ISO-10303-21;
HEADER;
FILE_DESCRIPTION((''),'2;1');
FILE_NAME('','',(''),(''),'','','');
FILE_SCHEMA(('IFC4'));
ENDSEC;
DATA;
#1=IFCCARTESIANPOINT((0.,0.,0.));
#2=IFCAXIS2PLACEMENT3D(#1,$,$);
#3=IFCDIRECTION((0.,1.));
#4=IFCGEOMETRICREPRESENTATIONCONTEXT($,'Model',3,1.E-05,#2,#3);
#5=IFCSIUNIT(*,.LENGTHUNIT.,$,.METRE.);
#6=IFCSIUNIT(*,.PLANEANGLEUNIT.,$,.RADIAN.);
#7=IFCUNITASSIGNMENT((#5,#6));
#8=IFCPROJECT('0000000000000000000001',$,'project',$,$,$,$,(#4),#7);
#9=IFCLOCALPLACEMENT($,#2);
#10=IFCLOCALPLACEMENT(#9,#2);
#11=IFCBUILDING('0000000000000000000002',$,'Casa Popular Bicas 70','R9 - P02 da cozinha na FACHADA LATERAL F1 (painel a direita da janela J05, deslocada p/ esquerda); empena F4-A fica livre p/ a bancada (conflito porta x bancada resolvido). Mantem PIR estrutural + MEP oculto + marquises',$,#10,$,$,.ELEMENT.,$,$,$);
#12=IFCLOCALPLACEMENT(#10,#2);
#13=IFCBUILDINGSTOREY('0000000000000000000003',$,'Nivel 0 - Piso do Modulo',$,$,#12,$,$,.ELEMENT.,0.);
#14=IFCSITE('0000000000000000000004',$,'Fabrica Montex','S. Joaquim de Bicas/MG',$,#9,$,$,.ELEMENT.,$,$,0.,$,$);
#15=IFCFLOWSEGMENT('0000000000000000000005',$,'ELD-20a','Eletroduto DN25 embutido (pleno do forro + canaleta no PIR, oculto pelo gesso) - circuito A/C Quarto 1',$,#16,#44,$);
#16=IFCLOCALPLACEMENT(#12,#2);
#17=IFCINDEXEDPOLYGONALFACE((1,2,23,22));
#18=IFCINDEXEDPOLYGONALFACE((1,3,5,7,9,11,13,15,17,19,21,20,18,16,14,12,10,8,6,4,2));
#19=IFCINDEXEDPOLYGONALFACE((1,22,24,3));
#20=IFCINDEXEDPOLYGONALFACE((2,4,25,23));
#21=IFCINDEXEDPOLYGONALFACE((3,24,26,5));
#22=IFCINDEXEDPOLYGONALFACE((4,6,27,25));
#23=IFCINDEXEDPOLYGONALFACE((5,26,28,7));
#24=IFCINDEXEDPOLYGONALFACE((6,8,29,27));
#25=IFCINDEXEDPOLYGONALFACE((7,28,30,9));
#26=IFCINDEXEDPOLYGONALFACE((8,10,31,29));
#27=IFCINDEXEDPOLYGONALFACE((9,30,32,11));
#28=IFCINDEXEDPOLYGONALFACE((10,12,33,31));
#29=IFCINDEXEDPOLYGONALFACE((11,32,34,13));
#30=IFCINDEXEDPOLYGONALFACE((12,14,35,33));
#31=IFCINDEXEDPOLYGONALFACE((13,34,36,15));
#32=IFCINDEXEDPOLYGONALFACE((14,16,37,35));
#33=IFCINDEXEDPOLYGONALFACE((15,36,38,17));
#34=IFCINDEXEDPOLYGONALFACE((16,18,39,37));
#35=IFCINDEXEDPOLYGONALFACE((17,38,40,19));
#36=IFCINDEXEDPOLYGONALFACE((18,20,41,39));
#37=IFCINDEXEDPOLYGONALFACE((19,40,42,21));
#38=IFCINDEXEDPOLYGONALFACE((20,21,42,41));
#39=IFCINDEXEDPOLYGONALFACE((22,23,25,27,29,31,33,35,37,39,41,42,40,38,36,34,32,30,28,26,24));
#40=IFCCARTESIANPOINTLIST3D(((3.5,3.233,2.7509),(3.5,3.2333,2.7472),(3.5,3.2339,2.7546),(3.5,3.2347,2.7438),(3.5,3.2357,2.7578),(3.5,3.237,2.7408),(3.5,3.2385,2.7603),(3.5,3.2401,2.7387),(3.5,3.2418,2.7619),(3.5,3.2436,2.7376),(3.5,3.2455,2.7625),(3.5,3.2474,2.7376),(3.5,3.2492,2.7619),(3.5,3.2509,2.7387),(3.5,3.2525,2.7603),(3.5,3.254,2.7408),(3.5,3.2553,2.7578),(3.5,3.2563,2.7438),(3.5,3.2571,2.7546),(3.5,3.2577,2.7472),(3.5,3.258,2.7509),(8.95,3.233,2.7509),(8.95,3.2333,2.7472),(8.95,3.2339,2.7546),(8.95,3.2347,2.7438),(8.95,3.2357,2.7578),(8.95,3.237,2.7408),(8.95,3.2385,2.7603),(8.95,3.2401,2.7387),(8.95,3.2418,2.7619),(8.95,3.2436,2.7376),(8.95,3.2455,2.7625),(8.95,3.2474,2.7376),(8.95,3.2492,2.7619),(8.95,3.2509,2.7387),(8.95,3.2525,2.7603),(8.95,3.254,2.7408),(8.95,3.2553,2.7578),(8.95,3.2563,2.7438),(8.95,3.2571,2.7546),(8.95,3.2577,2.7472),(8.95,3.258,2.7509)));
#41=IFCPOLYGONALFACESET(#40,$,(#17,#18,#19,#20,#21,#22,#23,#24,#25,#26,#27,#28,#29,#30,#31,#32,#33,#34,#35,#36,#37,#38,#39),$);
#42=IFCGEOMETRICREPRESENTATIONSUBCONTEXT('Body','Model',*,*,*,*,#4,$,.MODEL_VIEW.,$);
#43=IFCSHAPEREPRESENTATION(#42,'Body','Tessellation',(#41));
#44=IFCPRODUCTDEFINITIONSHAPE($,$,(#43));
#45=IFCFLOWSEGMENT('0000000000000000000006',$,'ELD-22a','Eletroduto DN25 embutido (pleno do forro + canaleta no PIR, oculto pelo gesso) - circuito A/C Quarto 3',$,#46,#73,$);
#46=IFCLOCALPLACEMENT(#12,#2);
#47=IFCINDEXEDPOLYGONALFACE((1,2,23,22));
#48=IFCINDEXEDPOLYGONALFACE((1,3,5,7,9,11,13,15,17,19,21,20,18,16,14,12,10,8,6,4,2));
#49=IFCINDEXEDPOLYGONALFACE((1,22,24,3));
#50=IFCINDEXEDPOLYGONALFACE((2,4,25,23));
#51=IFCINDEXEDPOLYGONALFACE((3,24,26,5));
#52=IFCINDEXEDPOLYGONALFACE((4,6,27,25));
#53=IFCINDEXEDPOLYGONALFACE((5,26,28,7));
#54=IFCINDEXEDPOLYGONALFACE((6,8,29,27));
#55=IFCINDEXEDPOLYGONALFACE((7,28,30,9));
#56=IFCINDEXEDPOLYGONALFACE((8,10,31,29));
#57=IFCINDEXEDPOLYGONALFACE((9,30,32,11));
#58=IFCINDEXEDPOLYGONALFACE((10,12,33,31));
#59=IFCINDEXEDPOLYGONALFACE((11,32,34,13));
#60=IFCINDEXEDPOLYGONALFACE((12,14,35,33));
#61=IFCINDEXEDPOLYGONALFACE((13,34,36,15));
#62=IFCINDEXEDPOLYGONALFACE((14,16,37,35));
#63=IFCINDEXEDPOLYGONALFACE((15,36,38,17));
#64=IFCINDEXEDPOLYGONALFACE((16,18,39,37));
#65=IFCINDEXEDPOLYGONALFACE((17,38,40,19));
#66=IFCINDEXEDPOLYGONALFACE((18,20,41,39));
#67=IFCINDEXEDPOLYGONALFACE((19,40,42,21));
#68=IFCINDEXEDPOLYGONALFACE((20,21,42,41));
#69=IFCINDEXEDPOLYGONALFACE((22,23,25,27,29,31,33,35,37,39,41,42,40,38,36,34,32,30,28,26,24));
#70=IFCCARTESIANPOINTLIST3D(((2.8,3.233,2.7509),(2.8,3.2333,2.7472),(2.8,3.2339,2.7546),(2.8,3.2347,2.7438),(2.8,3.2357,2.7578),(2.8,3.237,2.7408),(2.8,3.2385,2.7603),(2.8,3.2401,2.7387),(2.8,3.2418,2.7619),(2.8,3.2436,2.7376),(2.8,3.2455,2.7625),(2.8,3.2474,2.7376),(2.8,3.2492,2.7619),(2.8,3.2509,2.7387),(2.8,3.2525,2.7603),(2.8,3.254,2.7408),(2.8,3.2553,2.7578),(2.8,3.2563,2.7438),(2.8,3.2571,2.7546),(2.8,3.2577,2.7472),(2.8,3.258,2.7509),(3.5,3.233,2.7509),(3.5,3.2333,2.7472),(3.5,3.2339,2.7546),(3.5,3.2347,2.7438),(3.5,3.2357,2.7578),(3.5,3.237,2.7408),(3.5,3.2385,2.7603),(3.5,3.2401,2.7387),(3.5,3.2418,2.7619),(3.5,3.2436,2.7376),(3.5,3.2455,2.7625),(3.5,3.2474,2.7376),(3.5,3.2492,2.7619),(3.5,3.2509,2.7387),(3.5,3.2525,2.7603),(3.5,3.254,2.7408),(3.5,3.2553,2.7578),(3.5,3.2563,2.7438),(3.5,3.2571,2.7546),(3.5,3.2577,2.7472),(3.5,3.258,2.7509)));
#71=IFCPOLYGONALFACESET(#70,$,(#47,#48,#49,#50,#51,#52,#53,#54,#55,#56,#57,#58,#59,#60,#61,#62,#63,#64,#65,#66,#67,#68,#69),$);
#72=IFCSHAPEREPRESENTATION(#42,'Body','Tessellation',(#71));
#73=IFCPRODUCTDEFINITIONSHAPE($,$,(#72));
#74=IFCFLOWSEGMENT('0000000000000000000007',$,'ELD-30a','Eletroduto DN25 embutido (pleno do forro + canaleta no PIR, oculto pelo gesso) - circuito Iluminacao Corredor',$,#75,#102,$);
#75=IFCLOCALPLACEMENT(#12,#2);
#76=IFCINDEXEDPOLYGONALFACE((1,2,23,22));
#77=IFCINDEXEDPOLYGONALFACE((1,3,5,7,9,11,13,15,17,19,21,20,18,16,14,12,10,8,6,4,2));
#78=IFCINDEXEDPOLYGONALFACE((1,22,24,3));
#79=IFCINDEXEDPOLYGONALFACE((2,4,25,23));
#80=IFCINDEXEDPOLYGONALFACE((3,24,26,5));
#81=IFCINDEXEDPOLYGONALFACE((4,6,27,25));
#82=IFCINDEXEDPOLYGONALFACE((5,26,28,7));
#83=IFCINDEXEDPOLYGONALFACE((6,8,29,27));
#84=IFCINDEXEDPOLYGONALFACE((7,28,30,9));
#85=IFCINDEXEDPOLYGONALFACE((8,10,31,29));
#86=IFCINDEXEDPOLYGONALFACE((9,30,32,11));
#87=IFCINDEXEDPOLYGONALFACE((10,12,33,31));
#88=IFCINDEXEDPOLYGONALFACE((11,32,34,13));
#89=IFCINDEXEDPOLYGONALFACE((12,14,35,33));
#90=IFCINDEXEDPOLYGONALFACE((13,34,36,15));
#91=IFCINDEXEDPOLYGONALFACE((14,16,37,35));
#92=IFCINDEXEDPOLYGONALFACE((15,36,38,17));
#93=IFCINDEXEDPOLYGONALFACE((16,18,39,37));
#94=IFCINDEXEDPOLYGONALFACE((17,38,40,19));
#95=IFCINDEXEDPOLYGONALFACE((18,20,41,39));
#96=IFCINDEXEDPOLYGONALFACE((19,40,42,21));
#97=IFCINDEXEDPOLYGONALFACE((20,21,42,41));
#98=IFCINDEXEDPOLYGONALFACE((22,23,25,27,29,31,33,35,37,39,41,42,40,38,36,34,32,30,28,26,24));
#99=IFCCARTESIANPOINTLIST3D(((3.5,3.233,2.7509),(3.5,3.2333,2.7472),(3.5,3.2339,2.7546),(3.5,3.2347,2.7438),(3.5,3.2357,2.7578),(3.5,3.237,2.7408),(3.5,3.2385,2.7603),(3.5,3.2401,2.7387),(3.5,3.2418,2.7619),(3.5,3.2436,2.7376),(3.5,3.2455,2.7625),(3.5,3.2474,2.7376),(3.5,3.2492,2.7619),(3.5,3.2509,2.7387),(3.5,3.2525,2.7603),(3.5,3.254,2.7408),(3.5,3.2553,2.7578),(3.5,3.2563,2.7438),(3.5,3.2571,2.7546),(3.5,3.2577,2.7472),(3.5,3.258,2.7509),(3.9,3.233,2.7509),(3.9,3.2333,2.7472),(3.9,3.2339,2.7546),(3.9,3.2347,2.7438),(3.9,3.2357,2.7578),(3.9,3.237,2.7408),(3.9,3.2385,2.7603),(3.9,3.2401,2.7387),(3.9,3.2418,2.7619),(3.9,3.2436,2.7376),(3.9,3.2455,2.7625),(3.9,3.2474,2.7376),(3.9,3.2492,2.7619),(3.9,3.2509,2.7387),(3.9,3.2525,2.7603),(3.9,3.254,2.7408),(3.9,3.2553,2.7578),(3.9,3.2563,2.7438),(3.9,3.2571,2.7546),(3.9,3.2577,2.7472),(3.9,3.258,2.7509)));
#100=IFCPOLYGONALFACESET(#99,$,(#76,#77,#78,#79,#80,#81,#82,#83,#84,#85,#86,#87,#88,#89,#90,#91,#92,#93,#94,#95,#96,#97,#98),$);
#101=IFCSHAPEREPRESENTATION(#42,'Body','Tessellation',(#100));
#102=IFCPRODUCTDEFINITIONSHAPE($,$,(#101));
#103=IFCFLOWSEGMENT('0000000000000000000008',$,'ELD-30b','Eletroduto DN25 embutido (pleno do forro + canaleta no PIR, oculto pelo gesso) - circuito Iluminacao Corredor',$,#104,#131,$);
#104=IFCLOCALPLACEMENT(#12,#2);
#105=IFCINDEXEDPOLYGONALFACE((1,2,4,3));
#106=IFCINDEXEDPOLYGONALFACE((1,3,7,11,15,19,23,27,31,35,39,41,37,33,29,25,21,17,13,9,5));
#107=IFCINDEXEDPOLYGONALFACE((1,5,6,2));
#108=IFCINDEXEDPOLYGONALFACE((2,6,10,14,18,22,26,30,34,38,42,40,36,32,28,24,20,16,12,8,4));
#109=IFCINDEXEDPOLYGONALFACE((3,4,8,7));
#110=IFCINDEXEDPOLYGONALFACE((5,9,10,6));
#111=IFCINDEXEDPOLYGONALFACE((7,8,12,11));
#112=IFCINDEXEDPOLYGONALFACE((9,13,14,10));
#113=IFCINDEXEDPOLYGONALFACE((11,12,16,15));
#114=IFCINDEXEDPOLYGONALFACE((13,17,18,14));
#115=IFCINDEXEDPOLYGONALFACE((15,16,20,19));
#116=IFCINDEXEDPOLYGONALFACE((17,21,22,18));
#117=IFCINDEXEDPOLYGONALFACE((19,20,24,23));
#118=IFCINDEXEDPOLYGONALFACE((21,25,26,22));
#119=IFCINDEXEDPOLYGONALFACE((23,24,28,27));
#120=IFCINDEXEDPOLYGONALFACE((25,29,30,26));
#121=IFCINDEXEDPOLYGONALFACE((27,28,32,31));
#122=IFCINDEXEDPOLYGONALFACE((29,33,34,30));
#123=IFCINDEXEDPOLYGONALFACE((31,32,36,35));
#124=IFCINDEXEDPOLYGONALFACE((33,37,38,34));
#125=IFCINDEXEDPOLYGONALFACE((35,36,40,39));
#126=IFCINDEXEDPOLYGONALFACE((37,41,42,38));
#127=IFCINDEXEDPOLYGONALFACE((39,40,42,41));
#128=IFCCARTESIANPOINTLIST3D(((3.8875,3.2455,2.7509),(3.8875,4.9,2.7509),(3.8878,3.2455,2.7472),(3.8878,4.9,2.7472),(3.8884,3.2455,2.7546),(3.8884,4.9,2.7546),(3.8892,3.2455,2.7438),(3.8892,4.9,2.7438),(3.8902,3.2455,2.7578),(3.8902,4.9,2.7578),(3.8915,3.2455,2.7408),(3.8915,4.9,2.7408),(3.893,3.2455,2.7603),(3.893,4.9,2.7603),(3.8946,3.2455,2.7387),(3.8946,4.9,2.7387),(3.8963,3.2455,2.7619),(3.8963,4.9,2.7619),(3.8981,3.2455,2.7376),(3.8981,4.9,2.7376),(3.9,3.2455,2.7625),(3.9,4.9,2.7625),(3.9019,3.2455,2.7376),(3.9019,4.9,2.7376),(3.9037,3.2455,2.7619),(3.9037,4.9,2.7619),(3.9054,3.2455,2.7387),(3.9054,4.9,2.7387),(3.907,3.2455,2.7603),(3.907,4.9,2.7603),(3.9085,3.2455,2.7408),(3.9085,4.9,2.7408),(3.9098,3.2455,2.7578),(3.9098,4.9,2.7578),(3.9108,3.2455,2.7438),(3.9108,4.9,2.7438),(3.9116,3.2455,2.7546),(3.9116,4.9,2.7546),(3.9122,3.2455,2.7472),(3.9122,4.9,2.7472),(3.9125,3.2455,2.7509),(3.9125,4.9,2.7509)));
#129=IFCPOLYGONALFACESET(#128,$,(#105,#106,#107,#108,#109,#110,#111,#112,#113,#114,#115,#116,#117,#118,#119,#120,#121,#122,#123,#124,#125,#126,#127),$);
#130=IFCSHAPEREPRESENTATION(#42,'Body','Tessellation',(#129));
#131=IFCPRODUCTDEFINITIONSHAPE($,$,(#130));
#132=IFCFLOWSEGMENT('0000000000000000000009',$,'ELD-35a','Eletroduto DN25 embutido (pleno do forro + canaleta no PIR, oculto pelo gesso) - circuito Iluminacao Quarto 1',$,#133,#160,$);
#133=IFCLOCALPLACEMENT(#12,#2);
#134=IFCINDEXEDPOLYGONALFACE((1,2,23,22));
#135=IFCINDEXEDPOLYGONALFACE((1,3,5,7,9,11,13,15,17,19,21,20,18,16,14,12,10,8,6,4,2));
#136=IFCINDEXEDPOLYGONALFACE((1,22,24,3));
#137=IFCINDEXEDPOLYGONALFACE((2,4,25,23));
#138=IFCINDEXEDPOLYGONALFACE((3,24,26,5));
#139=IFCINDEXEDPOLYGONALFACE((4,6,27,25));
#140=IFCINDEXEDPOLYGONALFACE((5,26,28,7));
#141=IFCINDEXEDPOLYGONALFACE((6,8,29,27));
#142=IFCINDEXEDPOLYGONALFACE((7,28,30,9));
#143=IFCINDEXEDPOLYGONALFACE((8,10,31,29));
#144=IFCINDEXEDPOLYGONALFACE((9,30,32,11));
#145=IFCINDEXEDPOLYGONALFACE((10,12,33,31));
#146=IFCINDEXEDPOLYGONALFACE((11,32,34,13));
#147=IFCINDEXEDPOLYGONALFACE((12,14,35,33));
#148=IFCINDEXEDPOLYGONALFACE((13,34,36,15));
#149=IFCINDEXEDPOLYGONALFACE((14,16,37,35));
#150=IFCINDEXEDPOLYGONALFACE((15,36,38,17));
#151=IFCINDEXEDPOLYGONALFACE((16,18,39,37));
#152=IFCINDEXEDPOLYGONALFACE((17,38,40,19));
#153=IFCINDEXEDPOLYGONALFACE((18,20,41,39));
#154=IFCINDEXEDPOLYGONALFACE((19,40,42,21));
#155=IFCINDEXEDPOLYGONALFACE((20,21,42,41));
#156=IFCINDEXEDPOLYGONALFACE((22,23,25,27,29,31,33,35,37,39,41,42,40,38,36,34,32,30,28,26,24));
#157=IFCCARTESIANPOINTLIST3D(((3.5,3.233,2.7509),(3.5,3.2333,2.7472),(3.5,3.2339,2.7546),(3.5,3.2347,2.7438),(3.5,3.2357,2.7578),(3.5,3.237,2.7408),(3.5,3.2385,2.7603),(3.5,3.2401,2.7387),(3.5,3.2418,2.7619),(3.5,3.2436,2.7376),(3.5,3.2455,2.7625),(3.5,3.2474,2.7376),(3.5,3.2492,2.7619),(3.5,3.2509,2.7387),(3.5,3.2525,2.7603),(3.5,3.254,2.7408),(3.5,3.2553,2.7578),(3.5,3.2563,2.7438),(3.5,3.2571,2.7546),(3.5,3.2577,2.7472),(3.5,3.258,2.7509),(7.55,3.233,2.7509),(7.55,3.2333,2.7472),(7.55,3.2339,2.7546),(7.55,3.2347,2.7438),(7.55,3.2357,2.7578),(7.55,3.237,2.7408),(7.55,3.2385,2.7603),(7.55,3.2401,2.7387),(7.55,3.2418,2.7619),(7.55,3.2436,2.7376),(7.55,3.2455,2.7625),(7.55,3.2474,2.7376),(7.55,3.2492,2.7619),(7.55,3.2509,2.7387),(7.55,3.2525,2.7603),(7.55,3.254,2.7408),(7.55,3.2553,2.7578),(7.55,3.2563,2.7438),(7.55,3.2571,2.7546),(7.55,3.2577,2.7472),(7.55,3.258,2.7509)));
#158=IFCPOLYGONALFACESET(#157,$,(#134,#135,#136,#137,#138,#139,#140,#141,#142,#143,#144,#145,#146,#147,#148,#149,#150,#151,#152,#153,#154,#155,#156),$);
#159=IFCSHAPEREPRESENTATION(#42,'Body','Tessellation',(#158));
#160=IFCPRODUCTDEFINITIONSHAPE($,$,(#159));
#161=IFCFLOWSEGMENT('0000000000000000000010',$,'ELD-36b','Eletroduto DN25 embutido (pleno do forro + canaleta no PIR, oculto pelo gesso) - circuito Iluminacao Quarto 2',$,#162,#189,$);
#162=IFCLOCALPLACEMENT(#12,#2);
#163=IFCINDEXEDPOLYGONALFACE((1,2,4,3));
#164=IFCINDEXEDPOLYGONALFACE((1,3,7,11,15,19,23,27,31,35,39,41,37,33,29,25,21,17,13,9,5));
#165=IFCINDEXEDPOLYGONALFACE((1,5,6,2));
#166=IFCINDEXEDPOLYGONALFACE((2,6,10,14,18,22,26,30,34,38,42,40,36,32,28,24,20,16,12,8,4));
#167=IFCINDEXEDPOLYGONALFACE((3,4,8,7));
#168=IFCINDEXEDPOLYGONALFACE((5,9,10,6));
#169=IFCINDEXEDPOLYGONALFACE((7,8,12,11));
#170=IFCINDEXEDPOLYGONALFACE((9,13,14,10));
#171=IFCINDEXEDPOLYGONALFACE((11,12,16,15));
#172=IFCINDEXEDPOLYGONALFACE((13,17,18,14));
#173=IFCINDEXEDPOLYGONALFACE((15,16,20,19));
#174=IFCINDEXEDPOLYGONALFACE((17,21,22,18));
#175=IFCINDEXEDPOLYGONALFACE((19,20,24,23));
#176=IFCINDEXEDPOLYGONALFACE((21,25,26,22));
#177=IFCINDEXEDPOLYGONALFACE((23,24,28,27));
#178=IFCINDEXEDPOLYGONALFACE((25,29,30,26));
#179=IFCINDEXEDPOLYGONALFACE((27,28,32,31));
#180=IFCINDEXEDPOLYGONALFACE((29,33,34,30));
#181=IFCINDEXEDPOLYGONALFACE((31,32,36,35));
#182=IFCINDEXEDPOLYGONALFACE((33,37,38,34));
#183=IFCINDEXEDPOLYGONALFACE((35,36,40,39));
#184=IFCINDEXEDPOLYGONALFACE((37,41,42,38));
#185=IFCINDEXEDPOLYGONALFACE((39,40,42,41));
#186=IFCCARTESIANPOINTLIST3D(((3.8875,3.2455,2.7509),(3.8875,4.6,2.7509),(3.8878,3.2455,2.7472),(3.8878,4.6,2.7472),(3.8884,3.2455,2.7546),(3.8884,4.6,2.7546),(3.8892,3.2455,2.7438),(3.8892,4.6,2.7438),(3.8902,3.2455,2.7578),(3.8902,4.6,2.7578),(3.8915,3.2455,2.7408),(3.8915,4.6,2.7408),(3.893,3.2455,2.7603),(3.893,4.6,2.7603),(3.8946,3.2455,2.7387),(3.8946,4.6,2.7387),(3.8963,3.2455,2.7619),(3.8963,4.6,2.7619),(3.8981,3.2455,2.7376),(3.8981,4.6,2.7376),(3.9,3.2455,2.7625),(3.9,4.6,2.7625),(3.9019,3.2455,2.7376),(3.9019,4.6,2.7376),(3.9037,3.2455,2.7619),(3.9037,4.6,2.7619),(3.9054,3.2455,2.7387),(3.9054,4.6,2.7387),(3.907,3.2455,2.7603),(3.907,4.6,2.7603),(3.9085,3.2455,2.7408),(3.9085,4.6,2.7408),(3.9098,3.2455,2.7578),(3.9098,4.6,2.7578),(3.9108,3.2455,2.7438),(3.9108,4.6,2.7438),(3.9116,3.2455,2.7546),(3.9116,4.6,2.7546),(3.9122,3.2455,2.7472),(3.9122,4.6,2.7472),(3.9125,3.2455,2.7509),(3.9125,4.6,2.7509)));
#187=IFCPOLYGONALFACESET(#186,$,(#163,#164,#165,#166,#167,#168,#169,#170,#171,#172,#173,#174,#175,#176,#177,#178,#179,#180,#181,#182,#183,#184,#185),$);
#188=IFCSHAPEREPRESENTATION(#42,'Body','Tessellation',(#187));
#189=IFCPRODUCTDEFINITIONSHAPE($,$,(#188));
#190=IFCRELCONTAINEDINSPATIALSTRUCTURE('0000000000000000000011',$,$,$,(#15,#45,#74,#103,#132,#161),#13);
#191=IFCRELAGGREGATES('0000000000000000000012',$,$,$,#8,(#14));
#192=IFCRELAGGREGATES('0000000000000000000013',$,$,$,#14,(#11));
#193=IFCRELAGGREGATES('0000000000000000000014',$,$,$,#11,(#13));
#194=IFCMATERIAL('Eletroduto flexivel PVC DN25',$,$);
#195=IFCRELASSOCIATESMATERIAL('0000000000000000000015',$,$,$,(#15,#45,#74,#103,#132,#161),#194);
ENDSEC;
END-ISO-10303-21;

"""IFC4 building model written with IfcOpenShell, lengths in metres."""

from ifc_helpers import new_model, si_unit, direction, frame, origin, origin_2d, place, context, subcontext, project, spatial, circle, extrude, material, element, save


model = new_model("IFC4")

# Units and contexts
model_context = context("Model", 3, precision=1e-05, world=origin(), true_north=direction((0.0, 1.0)))
body_context = subcontext(model_context, "Body", "Model", "MODEL_VIEW")
ifc_project = project(units=[si_unit("LENGTHUNIT", "METRE"), si_unit("PLANEANGLEUNIT", "RADIAN")], contexts=[model_context])

# Site, building, storey
site_placement = place(None, origin())
site = spatial("IfcSite", under=ifc_project, at=site_placement, Name="Fabrica Montex", Description="S. Joaquim de Bicas/MG", CompositionType="ELEMENT", RefElevation=0.0)
building_placement = place(site_placement, origin())
building = spatial("IfcBuilding", under=site, at=building_placement, Name="Casa Popular Bicas 70", Description="R9 - P02 da cozinha na FACHADA LATERAL F1 (painel a direita da janela J05, deslocada p/ esquerda); empena F4-A fica livre p/ a bancada (conflito porta x bancada resolvido). Mantem PIR estrutural + MEP oculto + marquises", CompositionType="ELEMENT")
storey_placement = place(building_placement, origin())
storey = spatial("IfcBuildingStorey", under=building, at=storey_placement, Name="Nivel 0 - Piso do Modulo", CompositionType="ELEMENT", Elevation=0.0)

# Flow segments
ifc_material_1 = material(Name="Eletroduto flexivel PVC DN25")
flow_segment_1_placement = place(storey_placement, frame((3.5, 3.2455, 2.75), z_axis=(1.0, 0.0, 0.0), x_axis=(0.0, 0.0, 1.0)))
element("IfcFlowSegment", 1, at=flow_segment_1_placement, inside=storey, material=ifc_material_1, Name="ELD-20a", Description="Eletroduto DN25 embutido (pleno do forro + canaleta no PIR, oculto pelo gesso) - circuito A/C Quarto 1", context=body_context, shape_type="SweptSolid", body=[
    extrude(circle(Radius=0.0125, at=origin_2d()), origin(), (0.0, 0.0, 1.0), 5.45),
])
flow_segment_2_placement = place(storey_placement, frame((3.5, 3.2455, 2.75), z_axis=(-1.0, 0.0, 0.0), x_axis=(0.0, 0.0, 1.0)))
element("IfcFlowSegment", 2, at=flow_segment_2_placement, inside=storey, material=ifc_material_1, Name="ELD-22a", Description="Eletroduto DN25 embutido (pleno do forro + canaleta no PIR, oculto pelo gesso) - circuito A/C Quarto 3", context=body_context, shape_type="SweptSolid", body=[
    extrude(circle(Radius=0.0125, at=origin_2d()), origin(), (0.0, 0.0, 1.0), 0.7),
])
flow_segment_3_placement = place(storey_placement, frame((3.5, 3.2455, 2.75), z_axis=(1.0, 0.0, 0.0), x_axis=(0.0, 0.0, 1.0)))
element("IfcFlowSegment", 3, at=flow_segment_3_placement, inside=storey, material=ifc_material_1, Name="ELD-30a", Description="Eletroduto DN25 embutido (pleno do forro + canaleta no PIR, oculto pelo gesso) - circuito Iluminacao Corredor", context=body_context, shape_type="SweptSolid", body=[
    extrude(circle(Radius=0.0125, at=origin_2d()), origin(), (0.0, 0.0, 1.0), 0.4),
])
flow_segment_4_placement = place(storey_placement, frame((3.9, 3.2455, 2.75), z_axis=(0.0, 1.0, 0.0), x_axis=(0.0, 0.0, 1.0)))
element("IfcFlowSegment", 4, at=flow_segment_4_placement, inside=storey, material=ifc_material_1, Name="ELD-30b", Description="Eletroduto DN25 embutido (pleno do forro + canaleta no PIR, oculto pelo gesso) - circuito Iluminacao Corredor", context=body_context, shape_type="SweptSolid", body=[
    extrude(circle(Radius=0.0125, at=origin_2d()), origin(), (0.0, 0.0, 1.0), 1.6545),
])
flow_segment_5_placement = place(storey_placement, frame((3.5, 3.2455, 2.75), z_axis=(1.0, 0.0, 0.0), x_axis=(0.0, 0.0, 1.0)))
element("IfcFlowSegment", 5, at=flow_segment_5_placement, inside=storey, material=ifc_material_1, Name="ELD-35a", Description="Eletroduto DN25 embutido (pleno do forro + canaleta no PIR, oculto pelo gesso) - circuito Iluminacao Quarto 1", context=body_context, shape_type="SweptSolid", body=[
    extrude(circle(Radius=0.0125, at=origin_2d()), origin(), (0.0, 0.0, 1.0), 4.05),
])
flow_segment_6_placement = place(storey_placement, frame((3.9, 3.2455, 2.75), z_axis=(0.0, 1.0, 0.0), x_axis=(0.0, 0.0, 1.0)))
element("IfcFlowSegment", 6, at=flow_segment_6_placement, inside=storey, material=ifc_material_1, Name="ELD-36b", Description="Eletroduto DN25 embutido (pleno do forro + canaleta no PIR, oculto pelo gesso) - circuito Iluminacao Quarto 2", context=body_context, shape_type="SweptSolid", body=[
    extrude(circle(Radius=0.0125, at=origin_2d()), origin(), (0.0, 0.0, 1.0), 1.3545),
])

save(model, "model.ifc")
